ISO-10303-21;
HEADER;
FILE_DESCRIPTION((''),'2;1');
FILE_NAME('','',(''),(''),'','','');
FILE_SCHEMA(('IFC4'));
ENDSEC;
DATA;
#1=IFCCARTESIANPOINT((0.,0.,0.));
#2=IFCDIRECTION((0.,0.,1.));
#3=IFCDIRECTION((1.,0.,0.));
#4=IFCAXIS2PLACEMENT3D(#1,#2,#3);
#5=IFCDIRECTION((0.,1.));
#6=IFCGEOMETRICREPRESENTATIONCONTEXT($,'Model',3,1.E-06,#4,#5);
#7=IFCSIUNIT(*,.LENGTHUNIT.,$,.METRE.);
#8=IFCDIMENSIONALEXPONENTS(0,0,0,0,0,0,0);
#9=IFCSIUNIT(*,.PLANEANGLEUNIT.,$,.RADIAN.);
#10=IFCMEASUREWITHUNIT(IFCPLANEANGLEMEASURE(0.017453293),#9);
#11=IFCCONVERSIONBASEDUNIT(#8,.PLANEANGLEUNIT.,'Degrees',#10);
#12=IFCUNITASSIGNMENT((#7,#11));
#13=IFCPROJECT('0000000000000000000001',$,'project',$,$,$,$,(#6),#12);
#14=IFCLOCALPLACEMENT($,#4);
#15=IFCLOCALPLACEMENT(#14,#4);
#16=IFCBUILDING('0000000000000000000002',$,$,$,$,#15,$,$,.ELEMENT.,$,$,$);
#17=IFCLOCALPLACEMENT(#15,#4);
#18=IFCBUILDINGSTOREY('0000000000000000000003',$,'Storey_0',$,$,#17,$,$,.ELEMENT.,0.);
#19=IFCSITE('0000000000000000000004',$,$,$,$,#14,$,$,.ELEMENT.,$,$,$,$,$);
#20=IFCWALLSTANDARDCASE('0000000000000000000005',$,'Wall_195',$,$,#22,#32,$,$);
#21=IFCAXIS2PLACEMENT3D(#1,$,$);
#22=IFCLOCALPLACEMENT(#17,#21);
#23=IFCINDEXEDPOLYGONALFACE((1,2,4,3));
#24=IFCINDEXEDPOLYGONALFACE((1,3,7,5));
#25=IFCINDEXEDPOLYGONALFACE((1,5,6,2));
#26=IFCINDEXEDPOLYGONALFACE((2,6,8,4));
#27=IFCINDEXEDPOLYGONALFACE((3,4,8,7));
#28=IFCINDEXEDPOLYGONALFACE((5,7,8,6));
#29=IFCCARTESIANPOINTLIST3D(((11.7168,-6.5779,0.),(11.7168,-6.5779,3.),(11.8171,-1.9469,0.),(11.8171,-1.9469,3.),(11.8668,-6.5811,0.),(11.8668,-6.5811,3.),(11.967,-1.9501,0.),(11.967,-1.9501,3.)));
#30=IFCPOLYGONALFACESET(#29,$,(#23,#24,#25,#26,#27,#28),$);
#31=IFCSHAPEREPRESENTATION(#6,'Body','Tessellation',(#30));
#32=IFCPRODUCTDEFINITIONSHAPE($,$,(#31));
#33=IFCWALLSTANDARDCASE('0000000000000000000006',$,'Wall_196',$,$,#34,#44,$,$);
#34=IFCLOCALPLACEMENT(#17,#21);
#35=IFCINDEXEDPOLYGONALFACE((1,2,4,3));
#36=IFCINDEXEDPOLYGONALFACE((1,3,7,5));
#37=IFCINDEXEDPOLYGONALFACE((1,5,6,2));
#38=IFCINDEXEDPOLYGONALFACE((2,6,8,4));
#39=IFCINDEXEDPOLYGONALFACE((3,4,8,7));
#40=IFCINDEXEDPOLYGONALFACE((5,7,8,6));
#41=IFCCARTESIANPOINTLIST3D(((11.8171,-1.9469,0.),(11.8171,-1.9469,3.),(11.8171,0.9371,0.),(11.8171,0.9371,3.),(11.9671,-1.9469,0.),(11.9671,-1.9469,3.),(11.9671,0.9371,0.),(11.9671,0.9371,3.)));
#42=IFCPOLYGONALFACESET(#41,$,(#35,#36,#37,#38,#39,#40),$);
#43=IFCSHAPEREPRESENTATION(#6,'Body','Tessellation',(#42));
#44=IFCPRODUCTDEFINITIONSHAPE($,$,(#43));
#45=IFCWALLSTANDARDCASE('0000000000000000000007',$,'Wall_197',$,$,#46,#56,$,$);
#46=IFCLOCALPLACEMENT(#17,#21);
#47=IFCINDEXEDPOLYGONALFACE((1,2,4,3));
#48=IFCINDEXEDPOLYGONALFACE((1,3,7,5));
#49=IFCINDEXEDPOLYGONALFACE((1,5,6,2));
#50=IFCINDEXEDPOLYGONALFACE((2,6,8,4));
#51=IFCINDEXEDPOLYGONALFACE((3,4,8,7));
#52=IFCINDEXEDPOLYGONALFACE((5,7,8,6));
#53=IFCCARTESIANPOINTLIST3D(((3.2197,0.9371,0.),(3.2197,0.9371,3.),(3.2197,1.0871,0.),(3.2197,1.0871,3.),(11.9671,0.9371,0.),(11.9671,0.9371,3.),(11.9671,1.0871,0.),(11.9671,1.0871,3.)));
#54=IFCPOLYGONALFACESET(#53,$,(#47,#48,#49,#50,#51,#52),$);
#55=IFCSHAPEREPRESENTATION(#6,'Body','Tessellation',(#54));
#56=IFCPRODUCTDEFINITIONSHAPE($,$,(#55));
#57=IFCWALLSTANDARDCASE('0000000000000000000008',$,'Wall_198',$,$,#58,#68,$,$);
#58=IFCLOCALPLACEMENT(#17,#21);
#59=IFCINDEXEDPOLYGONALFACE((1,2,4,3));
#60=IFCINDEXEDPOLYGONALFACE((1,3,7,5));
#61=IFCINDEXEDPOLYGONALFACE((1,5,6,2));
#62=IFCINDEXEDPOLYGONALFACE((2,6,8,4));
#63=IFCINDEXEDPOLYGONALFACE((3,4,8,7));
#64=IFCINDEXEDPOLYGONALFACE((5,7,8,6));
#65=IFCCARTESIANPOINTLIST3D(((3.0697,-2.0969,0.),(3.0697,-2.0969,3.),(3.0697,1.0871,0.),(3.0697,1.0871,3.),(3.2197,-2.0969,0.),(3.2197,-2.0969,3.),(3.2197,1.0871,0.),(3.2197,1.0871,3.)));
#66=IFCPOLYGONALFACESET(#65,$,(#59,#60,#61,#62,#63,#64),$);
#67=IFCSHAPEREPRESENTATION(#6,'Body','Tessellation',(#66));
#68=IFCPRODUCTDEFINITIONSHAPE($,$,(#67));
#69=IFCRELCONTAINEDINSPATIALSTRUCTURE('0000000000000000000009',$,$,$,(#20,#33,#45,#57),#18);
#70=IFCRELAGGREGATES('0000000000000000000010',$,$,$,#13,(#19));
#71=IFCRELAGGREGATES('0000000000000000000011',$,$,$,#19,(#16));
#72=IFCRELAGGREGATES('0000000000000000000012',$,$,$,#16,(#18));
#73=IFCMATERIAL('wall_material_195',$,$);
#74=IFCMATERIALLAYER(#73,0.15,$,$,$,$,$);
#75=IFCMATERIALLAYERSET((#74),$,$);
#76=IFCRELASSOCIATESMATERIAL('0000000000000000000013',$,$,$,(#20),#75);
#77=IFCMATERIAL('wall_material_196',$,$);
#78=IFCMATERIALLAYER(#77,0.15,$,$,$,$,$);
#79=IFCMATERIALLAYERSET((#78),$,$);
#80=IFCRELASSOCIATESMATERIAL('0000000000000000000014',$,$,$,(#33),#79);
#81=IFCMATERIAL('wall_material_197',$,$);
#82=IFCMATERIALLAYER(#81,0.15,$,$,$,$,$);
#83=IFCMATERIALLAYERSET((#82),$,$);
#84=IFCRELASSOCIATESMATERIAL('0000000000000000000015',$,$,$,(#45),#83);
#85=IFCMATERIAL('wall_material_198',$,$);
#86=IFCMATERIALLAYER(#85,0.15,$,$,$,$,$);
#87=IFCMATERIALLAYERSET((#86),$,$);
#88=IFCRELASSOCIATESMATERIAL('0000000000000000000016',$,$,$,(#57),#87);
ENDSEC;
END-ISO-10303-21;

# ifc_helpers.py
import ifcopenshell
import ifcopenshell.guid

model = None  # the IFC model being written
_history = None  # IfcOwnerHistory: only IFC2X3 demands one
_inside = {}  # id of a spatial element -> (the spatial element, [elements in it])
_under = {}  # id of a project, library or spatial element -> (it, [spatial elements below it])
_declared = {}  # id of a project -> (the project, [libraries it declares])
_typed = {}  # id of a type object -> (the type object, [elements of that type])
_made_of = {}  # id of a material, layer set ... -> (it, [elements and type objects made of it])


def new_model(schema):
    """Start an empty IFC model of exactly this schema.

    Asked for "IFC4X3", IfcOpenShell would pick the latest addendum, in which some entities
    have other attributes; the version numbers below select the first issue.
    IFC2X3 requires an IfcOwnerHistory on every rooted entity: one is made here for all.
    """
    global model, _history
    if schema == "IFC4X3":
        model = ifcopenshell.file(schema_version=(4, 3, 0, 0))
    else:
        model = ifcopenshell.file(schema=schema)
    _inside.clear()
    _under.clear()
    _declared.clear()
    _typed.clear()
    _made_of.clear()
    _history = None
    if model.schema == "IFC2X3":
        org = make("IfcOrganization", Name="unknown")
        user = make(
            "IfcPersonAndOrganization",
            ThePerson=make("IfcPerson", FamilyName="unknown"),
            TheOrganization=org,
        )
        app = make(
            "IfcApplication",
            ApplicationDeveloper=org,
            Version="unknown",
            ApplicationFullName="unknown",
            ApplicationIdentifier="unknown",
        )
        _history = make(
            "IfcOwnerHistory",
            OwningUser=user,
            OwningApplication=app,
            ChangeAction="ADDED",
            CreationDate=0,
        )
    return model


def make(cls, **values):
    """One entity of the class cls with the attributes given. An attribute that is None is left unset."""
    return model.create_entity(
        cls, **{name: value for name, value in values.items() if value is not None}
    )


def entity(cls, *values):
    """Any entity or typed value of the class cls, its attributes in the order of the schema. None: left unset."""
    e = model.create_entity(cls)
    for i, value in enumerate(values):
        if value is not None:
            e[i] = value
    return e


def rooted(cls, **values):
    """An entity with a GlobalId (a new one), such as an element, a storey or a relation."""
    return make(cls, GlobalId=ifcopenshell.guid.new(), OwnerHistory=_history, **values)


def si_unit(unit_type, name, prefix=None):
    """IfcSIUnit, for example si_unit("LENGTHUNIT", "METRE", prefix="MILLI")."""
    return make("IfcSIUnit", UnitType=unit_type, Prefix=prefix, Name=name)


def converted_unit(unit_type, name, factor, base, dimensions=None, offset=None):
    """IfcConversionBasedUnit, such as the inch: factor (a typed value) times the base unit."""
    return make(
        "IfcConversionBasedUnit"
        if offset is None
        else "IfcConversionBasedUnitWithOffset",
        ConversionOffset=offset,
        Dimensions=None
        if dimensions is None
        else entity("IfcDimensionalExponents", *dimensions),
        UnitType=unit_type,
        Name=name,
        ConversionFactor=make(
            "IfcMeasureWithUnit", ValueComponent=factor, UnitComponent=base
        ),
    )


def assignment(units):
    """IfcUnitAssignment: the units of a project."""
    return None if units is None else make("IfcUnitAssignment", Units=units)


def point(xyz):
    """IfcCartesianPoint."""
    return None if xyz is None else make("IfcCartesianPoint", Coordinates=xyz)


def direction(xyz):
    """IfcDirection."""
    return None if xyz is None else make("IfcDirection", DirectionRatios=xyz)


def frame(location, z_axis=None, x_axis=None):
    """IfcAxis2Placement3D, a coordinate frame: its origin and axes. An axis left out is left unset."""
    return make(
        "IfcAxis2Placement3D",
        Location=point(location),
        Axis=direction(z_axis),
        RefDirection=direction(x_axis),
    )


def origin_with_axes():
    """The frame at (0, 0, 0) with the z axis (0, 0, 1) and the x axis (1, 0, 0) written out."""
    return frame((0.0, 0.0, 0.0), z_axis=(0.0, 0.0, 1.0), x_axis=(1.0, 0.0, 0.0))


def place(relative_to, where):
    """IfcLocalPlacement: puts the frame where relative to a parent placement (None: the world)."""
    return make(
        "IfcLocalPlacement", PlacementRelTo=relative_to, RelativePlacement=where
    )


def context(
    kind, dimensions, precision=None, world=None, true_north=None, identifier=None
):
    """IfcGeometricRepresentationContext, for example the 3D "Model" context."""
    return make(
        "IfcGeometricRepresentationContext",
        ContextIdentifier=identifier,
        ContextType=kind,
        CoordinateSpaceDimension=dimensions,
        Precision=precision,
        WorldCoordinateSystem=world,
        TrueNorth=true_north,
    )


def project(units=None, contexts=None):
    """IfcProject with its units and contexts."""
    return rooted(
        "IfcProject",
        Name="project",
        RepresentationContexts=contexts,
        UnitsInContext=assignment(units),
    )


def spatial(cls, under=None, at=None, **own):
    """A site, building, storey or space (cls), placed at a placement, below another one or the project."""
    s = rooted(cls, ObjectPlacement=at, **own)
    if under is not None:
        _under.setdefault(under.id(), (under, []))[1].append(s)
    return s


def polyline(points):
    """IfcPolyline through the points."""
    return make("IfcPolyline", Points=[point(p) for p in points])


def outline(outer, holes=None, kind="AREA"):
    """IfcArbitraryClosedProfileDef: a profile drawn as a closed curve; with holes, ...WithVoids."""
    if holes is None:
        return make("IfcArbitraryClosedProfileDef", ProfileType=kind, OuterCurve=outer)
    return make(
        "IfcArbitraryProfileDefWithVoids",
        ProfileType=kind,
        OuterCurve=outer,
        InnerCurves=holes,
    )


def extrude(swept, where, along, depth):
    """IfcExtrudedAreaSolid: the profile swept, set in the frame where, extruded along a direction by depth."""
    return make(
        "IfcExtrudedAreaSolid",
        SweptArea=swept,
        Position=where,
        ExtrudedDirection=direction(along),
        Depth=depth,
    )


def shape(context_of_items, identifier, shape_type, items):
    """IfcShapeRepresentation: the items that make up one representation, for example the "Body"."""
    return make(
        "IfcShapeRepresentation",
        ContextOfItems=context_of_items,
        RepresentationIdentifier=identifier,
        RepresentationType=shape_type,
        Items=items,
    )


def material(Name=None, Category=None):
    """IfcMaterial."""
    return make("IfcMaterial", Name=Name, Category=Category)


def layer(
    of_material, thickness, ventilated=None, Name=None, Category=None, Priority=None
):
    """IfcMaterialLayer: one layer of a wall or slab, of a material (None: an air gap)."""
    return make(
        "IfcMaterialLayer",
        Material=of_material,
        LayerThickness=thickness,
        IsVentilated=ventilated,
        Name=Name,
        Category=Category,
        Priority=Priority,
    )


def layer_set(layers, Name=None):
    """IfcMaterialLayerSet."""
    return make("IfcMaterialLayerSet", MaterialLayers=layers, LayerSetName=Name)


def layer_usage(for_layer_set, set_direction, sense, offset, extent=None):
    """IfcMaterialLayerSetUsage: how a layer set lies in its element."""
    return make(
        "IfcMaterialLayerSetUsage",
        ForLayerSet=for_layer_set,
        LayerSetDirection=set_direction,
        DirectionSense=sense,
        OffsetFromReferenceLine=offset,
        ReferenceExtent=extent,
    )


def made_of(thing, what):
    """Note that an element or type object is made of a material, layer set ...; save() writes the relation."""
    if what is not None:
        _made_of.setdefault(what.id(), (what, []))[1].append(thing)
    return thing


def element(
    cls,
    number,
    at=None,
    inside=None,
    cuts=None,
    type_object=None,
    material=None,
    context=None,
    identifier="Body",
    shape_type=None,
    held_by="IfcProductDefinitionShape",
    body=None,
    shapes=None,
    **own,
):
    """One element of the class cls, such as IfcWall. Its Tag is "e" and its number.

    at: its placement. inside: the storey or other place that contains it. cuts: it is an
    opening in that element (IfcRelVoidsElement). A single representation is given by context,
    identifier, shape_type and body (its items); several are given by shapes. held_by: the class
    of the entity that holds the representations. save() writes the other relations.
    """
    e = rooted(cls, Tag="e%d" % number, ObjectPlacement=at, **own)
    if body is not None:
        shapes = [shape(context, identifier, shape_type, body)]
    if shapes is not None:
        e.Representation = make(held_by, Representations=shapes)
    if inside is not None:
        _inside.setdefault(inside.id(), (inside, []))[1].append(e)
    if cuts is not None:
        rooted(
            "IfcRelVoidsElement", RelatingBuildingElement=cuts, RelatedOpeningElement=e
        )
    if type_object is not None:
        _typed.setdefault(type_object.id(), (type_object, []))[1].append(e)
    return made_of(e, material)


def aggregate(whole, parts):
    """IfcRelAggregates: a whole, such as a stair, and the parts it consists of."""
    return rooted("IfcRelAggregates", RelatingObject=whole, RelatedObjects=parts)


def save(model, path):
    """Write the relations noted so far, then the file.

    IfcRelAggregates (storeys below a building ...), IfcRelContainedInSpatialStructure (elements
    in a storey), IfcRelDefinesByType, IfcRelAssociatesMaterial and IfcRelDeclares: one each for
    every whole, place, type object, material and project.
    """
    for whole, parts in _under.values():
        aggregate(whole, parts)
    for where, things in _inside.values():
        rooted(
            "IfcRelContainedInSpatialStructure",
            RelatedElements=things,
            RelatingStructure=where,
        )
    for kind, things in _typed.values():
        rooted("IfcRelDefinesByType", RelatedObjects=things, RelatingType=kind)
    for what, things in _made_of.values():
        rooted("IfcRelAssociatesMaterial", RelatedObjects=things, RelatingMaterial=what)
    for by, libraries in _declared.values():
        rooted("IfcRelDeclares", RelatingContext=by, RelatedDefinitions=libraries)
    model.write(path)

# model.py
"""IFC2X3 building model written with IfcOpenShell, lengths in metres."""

from ifc_helpers import new_model, entity, si_unit, converted_unit, direction, frame, origin_with_axes, place, context, project, spatial, polyline, outline, extrude, material, layer, layer_set, layer_usage, element, save


model = new_model("IFC2X3")

# Units and contexts
model_context = context("Model", 3, precision=1e-06, world=origin_with_axes(), true_north=direction((0.0, 1.0)))
ifc_project = project(units=[si_unit("LENGTHUNIT", "METRE"), converted_unit("PLANEANGLEUNIT", "Degrees", entity("IfcPlaneAngleMeasure", 0.017453293), si_unit("PLANEANGLEUNIT", "RADIAN"), dimensions=[0, 0, 0, 0, 0, 0, 0])], contexts=[model_context])

# Site, building, storey
site_placement = place(None, origin_with_axes())
site = spatial("IfcSite", under=ifc_project, at=site_placement, CompositionType="ELEMENT")
building_placement = place(site_placement, origin_with_axes())
building = spatial("IfcBuilding", under=site, at=building_placement, CompositionType="ELEMENT")
storey_placement = place(building_placement, origin_with_axes())
storey = spatial("IfcBuildingStorey", under=building, at=storey_placement, Name="Storey_0", CompositionType="ELEMENT", Elevation=0.0)

# Walls
ifc_material_1 = material(Name="wall_material_195")
ifc_layer_1 = layer(ifc_material_1, 0.15)
ifc_layer_set_1 = layer_set([ifc_layer_1])
ifc_layer_usage_1 = layer_usage(ifc_layer_set_1, "AXIS2", "NEGATIVE", 0.0)
wall_1_placement = place(storey_placement, frame((11.967, -1.9501, 0.0), z_axis=(0.0, 0.0, 1.0), x_axis=(-0.02164, -0.999766, 0.0)))
element("IfcWallStandardCase", 1, at=wall_1_placement, inside=storey, material=ifc_layer_usage_1, Name="Wall_195", context=model_context, shape_type="SweptSolid", body=[
    extrude(outline(polyline([(0.0, 0.0), (4.6321, 0.0), (4.6321, -0.15), (0.0, -0.15), (0.0, 0.0)])), origin_with_axes(), (0.0, 0.0, 1.0), 3.0),
])
ifc_material_2 = material(Name="wall_material_196")
ifc_layer_2 = layer(ifc_material_2, 0.15)
ifc_layer_set_2 = layer_set([ifc_layer_2])
ifc_layer_usage_2 = layer_usage(ifc_layer_set_2, "AXIS2", "NEGATIVE", 0.0)
wall_2_placement = place(storey_placement, frame((11.8171, -1.9469, 0.0), z_axis=(0.0, 0.0, 1.0), x_axis=(0.0, 1.0, 0.0)))
element("IfcWallStandardCase", 2, at=wall_2_placement, inside=storey, material=ifc_layer_usage_2, Name="Wall_196", context=model_context, shape_type="SweptSolid", body=[
    extrude(outline(polyline([(0.0, 0.0), (2.8839, 0.0), (2.8839, -0.15), (0.0, -0.15), (0.0, 0.0)])), origin_with_axes(), (0.0, 0.0, 1.0), 3.0),
])
ifc_material_3 = material(Name="wall_material_197")
ifc_layer_3 = layer(ifc_material_3, 0.15)
ifc_layer_set_3 = layer_set([ifc_layer_3])
ifc_layer_usage_3 = layer_usage(ifc_layer_set_3, "AXIS2", "NEGATIVE", 0.0)
wall_3_placement = place(storey_placement, frame((11.9671, 0.9371, 0.0), z_axis=(0.0, 0.0, 1.0), x_axis=(-1.0, 0.0, 0.0)))
element("IfcWallStandardCase", 3, at=wall_3_placement, inside=storey, material=ifc_layer_usage_3, Name="Wall_197", context=model_context, shape_type="SweptSolid", body=[
    extrude(outline(polyline([(0.0, 0.0), (8.7474, 0.0), (8.7474, -0.15), (0.0, -0.15), (0.0, 0.0)])), origin_with_axes(), (0.0, 0.0, 1.0), 3.0),
])
ifc_material_4 = material(Name="wall_material_198")
ifc_layer_4 = layer(ifc_material_4, 0.15)
ifc_layer_set_4 = layer_set([ifc_layer_4])
ifc_layer_usage_4 = layer_usage(ifc_layer_set_4, "AXIS2", "NEGATIVE", 0.0)
wall_4_placement = place(storey_placement, frame((3.2197, 1.0871, 0.0), z_axis=(0.0, 0.0, 1.0), x_axis=(0.0, -1.0, 0.0)))
element("IfcWallStandardCase", 4, at=wall_4_placement, inside=storey, material=ifc_layer_usage_4, Name="Wall_198", context=model_context, shape_type="SweptSolid", body=[
    extrude(outline(polyline([(0.0, 0.0), (3.1839, 0.0), (3.1839, -0.15), (0.0, -0.15), (0.0, 0.0)])), origin_with_axes(), (0.0, 0.0, 1.0), 3.0),
])

save(model, "model.ifc")
